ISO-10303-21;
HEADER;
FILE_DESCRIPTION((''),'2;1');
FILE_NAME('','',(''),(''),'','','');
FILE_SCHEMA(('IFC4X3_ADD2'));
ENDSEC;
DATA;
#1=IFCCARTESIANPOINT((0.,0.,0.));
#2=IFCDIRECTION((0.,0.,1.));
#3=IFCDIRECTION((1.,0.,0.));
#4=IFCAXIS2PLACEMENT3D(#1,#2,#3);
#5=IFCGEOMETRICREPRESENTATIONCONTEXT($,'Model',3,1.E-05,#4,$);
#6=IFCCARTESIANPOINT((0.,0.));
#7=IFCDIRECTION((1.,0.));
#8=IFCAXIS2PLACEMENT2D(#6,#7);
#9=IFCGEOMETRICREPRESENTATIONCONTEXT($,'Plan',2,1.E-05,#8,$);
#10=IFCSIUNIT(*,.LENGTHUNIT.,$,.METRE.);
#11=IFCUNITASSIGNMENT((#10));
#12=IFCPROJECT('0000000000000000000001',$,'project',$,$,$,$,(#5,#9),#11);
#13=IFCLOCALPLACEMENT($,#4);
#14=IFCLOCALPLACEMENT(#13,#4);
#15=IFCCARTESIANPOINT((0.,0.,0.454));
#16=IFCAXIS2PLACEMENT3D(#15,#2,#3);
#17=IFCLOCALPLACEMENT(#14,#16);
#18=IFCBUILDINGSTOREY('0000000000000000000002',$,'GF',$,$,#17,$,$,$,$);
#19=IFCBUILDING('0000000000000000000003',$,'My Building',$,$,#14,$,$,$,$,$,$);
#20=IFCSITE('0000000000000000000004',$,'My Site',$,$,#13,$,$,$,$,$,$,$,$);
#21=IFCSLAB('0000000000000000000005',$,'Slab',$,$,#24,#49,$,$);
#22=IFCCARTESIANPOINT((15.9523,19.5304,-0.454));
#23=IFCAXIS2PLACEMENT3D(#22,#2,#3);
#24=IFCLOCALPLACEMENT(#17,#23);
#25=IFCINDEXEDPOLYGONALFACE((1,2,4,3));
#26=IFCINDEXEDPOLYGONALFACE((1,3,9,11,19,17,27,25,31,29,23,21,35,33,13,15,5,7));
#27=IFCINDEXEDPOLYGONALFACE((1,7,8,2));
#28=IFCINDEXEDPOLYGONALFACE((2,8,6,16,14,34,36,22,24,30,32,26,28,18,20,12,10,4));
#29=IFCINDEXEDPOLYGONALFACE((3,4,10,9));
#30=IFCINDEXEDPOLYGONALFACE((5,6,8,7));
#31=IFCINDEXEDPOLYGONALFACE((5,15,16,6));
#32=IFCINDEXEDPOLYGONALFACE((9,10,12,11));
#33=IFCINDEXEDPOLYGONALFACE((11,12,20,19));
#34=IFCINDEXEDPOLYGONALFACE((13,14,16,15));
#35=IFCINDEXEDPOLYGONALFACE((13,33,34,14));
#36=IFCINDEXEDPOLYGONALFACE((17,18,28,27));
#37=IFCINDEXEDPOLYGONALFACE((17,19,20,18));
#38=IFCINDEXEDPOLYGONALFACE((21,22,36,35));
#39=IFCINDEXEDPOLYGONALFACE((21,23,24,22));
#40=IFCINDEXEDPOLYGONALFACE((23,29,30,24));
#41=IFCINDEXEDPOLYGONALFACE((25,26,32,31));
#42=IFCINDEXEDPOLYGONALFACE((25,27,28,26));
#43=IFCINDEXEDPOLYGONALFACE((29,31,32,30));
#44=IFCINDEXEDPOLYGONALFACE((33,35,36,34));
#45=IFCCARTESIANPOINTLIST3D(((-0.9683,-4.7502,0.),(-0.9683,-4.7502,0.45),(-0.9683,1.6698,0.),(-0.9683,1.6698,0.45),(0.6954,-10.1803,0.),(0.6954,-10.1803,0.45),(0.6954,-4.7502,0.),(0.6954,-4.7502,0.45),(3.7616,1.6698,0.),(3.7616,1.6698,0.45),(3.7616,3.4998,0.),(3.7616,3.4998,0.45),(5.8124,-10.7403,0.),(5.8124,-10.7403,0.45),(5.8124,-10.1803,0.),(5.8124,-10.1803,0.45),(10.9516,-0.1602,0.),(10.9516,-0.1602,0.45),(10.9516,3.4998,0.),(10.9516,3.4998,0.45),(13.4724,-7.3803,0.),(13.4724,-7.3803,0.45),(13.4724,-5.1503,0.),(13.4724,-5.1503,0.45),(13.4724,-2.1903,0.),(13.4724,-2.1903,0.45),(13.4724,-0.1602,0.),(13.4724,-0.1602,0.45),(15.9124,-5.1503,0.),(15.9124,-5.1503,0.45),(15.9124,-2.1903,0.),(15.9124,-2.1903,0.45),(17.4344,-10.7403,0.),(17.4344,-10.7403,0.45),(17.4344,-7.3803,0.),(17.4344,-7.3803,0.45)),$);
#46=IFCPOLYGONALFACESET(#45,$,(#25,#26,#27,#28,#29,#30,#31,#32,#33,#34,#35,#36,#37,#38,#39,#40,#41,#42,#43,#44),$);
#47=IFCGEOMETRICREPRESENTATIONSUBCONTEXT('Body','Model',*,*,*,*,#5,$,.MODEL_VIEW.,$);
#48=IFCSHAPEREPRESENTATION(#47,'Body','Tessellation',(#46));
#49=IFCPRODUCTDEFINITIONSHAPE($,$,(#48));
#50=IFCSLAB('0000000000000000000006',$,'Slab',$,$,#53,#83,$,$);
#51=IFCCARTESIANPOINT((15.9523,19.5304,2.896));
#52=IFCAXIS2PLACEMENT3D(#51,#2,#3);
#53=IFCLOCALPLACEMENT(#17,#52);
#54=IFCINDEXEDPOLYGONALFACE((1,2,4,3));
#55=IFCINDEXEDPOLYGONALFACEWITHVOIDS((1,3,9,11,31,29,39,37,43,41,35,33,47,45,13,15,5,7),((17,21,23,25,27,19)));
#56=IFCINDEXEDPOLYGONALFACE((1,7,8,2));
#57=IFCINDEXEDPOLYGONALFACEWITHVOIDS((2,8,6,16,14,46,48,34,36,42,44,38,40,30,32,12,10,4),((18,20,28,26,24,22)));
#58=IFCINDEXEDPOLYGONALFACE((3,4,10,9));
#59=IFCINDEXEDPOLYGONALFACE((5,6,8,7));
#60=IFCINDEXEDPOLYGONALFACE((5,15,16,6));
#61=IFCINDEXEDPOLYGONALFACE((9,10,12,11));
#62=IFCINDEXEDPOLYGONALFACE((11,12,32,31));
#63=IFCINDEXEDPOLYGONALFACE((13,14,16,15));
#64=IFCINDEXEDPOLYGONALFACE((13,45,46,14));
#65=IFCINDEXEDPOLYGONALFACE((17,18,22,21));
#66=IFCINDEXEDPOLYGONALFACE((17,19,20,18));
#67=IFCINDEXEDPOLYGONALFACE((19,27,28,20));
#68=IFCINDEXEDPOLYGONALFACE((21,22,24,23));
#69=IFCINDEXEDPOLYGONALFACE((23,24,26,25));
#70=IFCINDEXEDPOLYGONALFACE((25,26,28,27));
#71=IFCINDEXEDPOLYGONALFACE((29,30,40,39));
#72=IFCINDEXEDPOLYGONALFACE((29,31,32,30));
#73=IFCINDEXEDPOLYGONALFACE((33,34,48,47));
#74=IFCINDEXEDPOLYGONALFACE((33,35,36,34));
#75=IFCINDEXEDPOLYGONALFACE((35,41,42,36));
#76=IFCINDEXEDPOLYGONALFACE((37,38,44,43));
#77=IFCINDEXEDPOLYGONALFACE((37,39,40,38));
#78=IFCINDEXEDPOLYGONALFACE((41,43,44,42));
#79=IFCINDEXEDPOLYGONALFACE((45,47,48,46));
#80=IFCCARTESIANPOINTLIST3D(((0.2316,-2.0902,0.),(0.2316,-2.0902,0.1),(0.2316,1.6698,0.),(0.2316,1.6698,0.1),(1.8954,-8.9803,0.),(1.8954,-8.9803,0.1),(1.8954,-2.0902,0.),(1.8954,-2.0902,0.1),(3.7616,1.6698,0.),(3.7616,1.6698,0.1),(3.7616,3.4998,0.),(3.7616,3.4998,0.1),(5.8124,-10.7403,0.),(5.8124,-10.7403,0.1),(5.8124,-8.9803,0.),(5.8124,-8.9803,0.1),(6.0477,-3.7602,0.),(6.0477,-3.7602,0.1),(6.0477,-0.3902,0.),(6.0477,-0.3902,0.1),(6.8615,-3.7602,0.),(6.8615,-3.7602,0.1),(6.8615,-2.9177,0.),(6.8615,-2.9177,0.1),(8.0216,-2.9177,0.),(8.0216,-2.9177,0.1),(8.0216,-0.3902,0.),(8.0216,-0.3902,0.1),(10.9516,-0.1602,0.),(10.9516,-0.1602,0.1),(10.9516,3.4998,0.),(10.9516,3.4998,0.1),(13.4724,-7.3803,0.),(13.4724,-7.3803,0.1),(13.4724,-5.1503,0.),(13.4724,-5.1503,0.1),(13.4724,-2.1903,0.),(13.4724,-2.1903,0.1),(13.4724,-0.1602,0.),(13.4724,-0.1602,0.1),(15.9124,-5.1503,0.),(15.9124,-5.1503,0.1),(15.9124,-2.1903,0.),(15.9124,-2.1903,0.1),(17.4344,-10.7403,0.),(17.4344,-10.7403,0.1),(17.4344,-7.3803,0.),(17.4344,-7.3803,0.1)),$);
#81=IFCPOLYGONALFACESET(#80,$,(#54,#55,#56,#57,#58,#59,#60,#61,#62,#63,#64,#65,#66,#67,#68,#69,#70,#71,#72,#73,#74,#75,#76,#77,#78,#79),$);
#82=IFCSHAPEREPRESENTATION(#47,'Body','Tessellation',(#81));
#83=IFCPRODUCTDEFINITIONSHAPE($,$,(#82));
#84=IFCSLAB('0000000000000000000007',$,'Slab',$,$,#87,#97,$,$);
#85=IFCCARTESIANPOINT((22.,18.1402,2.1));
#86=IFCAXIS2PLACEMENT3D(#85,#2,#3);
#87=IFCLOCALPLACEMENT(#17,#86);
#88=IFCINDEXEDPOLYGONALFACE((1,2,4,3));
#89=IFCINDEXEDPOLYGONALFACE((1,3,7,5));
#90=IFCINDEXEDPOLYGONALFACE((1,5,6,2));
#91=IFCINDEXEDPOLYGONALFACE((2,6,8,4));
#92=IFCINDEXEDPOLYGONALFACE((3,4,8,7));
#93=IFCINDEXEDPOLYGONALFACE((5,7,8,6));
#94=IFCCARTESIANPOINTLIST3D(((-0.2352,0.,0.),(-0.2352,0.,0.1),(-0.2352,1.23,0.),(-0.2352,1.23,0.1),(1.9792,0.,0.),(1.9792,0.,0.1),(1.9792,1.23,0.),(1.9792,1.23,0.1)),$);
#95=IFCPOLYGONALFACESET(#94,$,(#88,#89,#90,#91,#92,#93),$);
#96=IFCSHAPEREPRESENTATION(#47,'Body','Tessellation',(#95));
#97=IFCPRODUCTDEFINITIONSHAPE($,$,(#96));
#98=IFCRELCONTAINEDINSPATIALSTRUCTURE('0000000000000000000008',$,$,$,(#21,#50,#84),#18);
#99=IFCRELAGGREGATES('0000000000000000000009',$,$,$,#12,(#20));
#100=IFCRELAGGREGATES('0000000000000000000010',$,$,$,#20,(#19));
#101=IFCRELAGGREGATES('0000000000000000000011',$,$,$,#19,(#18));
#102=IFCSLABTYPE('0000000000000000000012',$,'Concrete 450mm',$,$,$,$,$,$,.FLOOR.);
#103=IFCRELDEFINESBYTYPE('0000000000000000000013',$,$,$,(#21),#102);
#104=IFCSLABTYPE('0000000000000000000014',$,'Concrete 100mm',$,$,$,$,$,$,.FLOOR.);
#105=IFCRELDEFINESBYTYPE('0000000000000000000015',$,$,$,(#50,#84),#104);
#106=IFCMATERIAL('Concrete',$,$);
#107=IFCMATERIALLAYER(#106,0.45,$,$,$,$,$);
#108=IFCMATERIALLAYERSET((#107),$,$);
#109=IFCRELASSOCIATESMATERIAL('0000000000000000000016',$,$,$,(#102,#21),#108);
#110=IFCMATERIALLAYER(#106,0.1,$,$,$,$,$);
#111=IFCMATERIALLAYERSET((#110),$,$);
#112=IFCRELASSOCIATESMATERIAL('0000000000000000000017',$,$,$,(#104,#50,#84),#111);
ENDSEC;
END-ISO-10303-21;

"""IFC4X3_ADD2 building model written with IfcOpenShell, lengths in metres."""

from ifc_helpers import new_model, si_unit, frame, origin_with_axes, origin_2d_with_axis, place, context, subcontext, project, spatial, line, indexed_curve, outline, extrude, material, layer, layer_set, layer_usage, type_object, element, save


model = new_model("IFC4X3_ADD2")

# Units and contexts
model_context = context("Model", 3, precision=1e-05, world=origin_with_axes())
plan_context = context("Plan", 2, precision=1e-05, world=origin_2d_with_axis())
body_context_1 = subcontext(model_context, "Body", "Model", "MODEL_VIEW")
ifc_project = project(units=[si_unit("LENGTHUNIT", "METRE")], contexts=[model_context, plan_context])

# Site, building, storey
site_placement = place(None, origin_with_axes())
site = spatial("IfcSite", under=ifc_project, at=site_placement, Name="My Site")
building_placement = place(site_placement, origin_with_axes())
building = spatial("IfcBuilding", under=site, at=building_placement, Name="My Building")
storey_placement = place(building_placement, frame((0.0, 0.0, 0.454), z_axis=(0.0, 0.0, 1.0), x_axis=(1.0, 0.0, 0.0)))
storey = spatial("IfcBuildingStorey", under=building, at=storey_placement, Name="GF")

# Slabs
ifc_material_1 = material(Name="Concrete")
ifc_layer_1 = layer(ifc_material_1, 0.45)
ifc_layer_set_1 = layer_set([ifc_layer_1])
ifc_layer_usage_1 = layer_usage(ifc_layer_set_1, "AXIS3", "POSITIVE", 0.0)
slab_type_1 = type_object("IfcSlabType", Name="Concrete 450mm", PredefinedType="FLOOR", material=ifc_layer_set_1)
slab_1_placement = place(storey_placement, frame((15.9523, 19.5304, -0.454), z_axis=(0.0, 0.0, 1.0), x_axis=(1.0, 0.0, 0.0)))
element("IfcSlab", 1, at=slab_1_placement, inside=storey, type_object=slab_type_1, material=ifc_layer_usage_1, Name="Slab", context=body_context_1, shape_type="SweptSolid", body=[
    extrude(outline(indexed_curve([(-0.9683, -4.7502), (-0.9683, 1.6698), (3.7616, 1.6698), (3.7616, 3.4998), (10.9516, 3.4998), (10.9516, -0.1602), (13.4724, -0.1602), (13.4724, -2.1903), (15.9124, -2.1903), (15.9124, -5.1503), (13.4724, -5.1503), (13.4724, -7.3803), (17.4344, -7.3803), (17.4344, -10.7403), (5.8124, -10.7403), (5.8124, -10.1803), (0.6954, -10.1803), (0.6954, -4.7502)], segments=[line(18, 1), line(1, 2), line(2, 3), line(3, 4), line(4, 5), line(5, 6), line(6, 7), line(7, 8), line(8, 9), line(9, 10), line(10, 11), line(11, 12), line(12, 13), line(13, 14), line(14, 15), line(15, 16), line(16, 17), line(17, 18)], self_intersect=False)), None, (0.0, 0.0, 1.0), 0.45),
])
ifc_layer_2 = layer(ifc_material_1, 0.1)
ifc_layer_set_2 = layer_set([ifc_layer_2])
ifc_layer_usage_2 = layer_usage(ifc_layer_set_2, "AXIS3", "POSITIVE", 0.0)
slab_type_2 = type_object("IfcSlabType", Name="Concrete 100mm", PredefinedType="FLOOR", material=ifc_layer_set_2)
slab_2_placement = place(storey_placement, frame((15.9523, 19.5304, 2.896), z_axis=(0.0, 0.0, 1.0), x_axis=(1.0, 0.0, 0.0)))
element("IfcSlab", 2, at=slab_2_placement, inside=storey, type_object=slab_type_2, material=ifc_layer_usage_2, Name="Slab", context=body_context_1, shape_type="SweptSolid", body=[
    extrude(outline(indexed_curve([(0.2316, -2.0902), (0.2316, 1.6698), (3.7616, 1.6698), (3.7616, 3.4998), (10.9516, 3.4998), (10.9516, -0.1602), (13.4724, -0.1602), (13.4724, -2.1903), (15.9124, -2.1903), (15.9124, -5.1503), (13.4724, -5.1503), (13.4724, -7.3803), (17.4344, -7.3803), (17.4344, -10.7403), (5.8124, -10.7403), (5.8124, -8.9803), (1.8954, -8.9803), (1.8954, -2.0902), (8.0216, -0.3902), (6.8615, -3.7602), (6.0477, -3.7602), (6.0477, -0.3902), (8.0216, -2.9177), (6.8615, -2.9177)], segments=[line(16, 15), line(15, 14), line(14, 13), line(13, 12), line(12, 11), line(11, 10), line(10, 9), line(9, 8), line(8, 7), line(7, 6), line(6, 5), line(5, 4), line(4, 3), line(3, 2), line(2, 1), line(1, 18), line(18, 17), line(17, 16)], self_intersect=False), holes=[indexed_curve([(0.2316, -2.0902), (0.2316, 1.6698), (3.7616, 1.6698), (3.7616, 3.4998), (10.9516, 3.4998), (10.9516, -0.1602), (13.4724, -0.1602), (13.4724, -2.1903), (15.9124, -2.1903), (15.9124, -5.1503), (13.4724, -5.1503), (13.4724, -7.3803), (17.4344, -7.3803), (17.4344, -10.7403), (5.8124, -10.7403), (5.8124, -8.9803), (1.8954, -8.9803), (1.8954, -2.0902), (8.0216, -0.3902), (6.8615, -3.7602), (6.0477, -3.7602), (6.0477, -0.3902), (8.0216, -2.9177), (6.8615, -2.9177)], segments=[line(23, 19), line(19, 22), line(22, 21), line(21, 20), line(20, 24), line(24, 23)], self_intersect=False)]), None, (0.0, 0.0, 1.0), 0.1),
])
ifc_layer_usage_3 = layer_usage(ifc_layer_set_2, "AXIS3", "POSITIVE", 0.0)
slab_3_placement = place(storey_placement, frame((22.0, 18.1402, 2.1), z_axis=(0.0, 0.0, 1.0), x_axis=(1.0, 0.0, 0.0)))
element("IfcSlab", 3, at=slab_3_placement, inside=storey, type_object=slab_type_2, material=ifc_layer_usage_3, Name="Slab", context=body_context_1, shape_type="SweptSolid", body=[
    extrude(outline(indexed_curve([(1.9792, 0.0), (-0.2352, 0.0), (-0.2352, 1.23), (1.9792, 1.23)], segments=[line(3, 2), line(2, 1), line(1, 4), line(4, 3)], self_intersect=False)), None, (0.0, 0.0, 1.0), 0.1),
])

save(model, "model.ifc")
